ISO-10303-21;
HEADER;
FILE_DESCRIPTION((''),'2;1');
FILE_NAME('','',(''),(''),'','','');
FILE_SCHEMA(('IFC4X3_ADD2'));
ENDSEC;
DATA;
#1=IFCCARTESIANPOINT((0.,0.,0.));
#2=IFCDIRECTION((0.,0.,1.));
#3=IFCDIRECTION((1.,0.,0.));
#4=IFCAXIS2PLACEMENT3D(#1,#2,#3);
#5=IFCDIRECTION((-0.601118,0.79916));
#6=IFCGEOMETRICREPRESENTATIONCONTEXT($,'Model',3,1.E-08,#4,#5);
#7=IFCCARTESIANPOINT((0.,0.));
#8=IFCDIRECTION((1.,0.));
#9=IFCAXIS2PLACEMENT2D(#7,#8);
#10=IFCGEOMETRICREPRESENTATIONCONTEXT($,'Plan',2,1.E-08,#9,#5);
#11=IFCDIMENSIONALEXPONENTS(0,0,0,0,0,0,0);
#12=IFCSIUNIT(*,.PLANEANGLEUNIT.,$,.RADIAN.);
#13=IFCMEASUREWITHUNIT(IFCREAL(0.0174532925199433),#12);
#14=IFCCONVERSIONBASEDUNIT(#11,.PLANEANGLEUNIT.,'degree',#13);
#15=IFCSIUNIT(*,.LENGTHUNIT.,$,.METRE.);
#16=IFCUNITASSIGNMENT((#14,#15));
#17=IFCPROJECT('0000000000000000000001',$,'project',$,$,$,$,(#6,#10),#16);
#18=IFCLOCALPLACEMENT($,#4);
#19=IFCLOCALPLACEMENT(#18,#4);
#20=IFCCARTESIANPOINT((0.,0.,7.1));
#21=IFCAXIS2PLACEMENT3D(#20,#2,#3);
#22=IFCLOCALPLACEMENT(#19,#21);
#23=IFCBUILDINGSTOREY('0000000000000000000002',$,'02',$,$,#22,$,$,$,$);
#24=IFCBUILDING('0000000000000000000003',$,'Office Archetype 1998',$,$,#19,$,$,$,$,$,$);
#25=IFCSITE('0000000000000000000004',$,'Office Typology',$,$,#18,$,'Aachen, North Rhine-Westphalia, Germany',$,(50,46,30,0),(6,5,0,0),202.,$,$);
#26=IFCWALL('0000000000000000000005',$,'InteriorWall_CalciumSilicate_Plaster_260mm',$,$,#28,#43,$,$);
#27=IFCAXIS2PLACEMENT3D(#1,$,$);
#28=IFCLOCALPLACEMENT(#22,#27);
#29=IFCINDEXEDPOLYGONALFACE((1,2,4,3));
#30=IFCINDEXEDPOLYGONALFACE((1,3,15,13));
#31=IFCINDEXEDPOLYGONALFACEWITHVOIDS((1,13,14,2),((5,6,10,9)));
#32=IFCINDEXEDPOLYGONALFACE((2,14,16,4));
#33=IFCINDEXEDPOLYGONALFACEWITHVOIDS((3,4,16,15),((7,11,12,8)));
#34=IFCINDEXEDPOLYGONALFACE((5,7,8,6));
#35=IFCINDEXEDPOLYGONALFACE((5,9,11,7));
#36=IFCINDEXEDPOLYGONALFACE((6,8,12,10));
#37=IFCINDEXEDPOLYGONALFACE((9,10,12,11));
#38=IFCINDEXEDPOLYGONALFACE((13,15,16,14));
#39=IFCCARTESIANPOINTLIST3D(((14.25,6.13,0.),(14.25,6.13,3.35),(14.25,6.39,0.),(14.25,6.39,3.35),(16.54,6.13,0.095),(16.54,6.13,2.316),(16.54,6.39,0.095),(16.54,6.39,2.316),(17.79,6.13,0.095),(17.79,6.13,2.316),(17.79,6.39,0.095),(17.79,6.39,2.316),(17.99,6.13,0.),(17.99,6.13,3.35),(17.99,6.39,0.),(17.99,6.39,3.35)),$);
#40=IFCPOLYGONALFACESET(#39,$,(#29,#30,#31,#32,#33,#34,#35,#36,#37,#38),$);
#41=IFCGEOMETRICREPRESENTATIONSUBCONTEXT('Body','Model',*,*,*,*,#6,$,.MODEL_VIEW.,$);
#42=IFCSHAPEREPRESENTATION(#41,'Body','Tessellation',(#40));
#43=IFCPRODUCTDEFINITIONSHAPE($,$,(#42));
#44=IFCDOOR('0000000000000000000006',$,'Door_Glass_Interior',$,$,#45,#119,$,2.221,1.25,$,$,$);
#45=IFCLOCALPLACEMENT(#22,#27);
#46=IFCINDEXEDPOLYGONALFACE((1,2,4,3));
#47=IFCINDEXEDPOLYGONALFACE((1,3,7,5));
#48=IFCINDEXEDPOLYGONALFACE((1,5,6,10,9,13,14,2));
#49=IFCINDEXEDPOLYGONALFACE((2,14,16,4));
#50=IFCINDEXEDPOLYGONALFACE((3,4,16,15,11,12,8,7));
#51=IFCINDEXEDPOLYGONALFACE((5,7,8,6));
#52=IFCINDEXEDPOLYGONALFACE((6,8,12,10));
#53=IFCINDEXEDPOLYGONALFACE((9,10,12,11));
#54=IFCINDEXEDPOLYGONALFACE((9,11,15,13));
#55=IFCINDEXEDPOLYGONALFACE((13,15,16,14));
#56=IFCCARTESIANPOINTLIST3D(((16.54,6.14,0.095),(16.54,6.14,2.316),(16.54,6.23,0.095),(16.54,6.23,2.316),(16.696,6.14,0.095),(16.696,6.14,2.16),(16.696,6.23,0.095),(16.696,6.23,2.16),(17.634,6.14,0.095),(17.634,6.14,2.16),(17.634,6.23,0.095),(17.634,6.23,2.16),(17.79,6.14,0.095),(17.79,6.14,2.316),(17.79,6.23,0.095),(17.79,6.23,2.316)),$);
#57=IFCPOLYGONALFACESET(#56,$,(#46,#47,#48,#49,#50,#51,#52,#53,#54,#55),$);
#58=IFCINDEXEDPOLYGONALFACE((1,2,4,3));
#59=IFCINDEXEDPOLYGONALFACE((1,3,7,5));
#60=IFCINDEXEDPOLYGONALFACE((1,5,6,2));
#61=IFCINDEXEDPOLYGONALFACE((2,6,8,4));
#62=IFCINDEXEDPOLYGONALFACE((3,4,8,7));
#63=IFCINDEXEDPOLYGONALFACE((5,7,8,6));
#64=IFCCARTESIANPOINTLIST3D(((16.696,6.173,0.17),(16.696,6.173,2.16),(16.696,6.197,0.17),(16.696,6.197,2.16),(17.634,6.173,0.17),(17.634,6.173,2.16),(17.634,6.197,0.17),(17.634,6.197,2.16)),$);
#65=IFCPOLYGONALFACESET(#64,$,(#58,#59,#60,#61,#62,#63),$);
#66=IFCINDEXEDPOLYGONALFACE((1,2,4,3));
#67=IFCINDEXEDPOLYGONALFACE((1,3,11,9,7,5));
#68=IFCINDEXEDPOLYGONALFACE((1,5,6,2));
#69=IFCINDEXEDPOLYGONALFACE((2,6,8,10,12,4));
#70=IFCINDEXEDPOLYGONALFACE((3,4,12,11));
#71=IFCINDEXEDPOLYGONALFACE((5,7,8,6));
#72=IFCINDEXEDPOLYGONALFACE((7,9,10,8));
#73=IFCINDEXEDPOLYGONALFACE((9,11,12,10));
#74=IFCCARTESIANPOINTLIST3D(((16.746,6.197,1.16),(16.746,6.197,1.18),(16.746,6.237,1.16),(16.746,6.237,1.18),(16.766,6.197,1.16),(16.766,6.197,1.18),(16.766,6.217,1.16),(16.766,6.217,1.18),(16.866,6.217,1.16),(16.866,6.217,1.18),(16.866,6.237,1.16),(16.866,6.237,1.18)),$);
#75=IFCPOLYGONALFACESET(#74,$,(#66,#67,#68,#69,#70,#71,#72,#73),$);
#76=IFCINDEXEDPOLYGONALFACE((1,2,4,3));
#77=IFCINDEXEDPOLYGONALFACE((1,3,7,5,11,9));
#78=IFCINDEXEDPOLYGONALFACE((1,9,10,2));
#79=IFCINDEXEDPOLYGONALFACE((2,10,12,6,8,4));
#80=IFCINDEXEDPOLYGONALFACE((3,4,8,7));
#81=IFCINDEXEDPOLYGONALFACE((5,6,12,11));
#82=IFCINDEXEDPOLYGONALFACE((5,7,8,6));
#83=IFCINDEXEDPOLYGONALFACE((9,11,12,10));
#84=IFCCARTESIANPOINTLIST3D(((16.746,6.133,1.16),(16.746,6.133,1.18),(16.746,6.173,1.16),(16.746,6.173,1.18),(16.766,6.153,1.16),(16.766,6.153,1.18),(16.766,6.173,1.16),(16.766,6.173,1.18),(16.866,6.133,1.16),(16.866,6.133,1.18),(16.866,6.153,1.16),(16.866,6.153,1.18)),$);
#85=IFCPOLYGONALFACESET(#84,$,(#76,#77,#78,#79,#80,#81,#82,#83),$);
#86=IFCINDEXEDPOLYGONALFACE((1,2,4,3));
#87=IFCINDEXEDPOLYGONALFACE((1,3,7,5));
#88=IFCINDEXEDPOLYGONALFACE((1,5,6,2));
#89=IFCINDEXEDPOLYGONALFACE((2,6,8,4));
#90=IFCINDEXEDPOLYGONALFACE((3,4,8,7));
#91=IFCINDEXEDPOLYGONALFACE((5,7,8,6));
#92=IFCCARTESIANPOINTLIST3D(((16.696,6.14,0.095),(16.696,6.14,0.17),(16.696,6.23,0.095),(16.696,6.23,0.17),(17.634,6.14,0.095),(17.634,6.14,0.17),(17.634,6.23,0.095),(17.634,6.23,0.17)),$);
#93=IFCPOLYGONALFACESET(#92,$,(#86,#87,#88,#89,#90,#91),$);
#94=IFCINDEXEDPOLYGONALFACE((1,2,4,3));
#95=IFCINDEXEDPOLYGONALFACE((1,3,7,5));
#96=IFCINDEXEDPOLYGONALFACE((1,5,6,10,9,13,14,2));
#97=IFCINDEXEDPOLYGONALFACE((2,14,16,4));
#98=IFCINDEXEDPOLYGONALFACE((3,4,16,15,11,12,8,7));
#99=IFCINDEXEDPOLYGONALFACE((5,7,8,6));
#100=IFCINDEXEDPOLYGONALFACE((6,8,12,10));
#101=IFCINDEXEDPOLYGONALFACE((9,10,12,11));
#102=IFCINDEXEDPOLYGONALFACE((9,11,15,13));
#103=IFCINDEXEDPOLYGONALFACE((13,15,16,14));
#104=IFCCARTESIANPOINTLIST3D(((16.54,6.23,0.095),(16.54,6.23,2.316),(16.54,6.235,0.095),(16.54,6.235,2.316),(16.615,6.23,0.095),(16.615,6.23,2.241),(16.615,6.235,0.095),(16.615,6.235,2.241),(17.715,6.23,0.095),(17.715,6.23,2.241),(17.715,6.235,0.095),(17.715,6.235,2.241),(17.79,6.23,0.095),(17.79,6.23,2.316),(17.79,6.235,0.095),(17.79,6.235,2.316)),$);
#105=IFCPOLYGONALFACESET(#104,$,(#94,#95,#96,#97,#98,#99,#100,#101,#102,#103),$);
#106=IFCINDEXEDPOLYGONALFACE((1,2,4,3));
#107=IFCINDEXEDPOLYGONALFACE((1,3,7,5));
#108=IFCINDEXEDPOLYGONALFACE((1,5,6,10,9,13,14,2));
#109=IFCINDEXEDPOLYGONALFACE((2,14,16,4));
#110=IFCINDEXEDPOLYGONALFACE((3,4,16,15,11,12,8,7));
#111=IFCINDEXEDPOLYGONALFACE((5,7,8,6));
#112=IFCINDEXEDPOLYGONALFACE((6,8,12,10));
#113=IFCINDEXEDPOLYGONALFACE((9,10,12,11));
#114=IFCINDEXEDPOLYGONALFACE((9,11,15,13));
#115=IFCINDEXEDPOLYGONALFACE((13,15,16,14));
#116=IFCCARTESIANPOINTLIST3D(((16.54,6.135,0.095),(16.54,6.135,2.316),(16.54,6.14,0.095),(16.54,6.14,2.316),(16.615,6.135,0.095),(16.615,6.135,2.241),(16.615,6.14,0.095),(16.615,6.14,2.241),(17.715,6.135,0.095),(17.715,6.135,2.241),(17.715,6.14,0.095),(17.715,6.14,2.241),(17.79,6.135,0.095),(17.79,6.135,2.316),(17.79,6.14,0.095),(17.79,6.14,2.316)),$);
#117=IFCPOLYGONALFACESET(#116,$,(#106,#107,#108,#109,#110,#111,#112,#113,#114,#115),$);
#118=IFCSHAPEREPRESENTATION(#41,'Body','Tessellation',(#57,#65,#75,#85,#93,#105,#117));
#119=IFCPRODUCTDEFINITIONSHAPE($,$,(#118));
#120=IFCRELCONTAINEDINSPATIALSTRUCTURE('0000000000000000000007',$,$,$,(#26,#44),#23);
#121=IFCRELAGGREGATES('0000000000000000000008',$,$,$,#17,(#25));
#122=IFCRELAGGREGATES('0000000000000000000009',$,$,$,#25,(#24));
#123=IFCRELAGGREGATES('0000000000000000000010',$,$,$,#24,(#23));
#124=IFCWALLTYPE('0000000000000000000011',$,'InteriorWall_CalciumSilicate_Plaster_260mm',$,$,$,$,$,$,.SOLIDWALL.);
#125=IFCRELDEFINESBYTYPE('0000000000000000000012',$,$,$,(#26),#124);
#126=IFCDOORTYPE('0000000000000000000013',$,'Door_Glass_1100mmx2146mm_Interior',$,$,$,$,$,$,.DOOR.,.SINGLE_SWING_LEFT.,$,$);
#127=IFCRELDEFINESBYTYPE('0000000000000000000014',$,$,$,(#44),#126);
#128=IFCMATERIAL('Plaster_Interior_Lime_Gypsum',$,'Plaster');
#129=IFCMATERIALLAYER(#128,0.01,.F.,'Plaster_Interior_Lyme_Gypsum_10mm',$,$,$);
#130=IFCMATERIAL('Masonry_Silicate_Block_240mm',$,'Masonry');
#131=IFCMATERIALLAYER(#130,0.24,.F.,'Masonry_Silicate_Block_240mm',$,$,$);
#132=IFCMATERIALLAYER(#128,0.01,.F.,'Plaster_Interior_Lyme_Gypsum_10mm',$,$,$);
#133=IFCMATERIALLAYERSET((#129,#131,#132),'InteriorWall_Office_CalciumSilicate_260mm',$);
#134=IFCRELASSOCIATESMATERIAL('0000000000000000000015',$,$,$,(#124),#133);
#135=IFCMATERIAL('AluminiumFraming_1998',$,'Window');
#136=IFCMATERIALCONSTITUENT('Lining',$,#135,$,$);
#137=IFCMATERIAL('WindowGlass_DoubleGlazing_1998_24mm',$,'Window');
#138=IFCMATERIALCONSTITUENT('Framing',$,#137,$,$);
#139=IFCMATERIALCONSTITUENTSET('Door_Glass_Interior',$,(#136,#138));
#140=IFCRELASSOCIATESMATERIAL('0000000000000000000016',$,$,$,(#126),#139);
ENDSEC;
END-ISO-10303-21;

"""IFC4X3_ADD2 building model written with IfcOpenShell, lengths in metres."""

from ifc_helpers import new_model, entity, si_unit, converted_unit, direction, frame, origin_with_axes, origin_2d_with_axis, place, context, subcontext, project, spatial, line, indexed_curve, outline, extrude, source, transform, mapped, material, layer, layer_set, constituent, constituent_set, type_object, type_shapes, element, fill, save


model = new_model("IFC4X3_ADD2")

# Units and contexts
model_context = context("Model", 3, precision=1e-08, world=origin_with_axes(), true_north=direction((-0.601118, 0.79916)))
plan_context = context("Plan", 2, precision=1e-08, world=origin_2d_with_axis(), true_north=direction((-0.601118, 0.79916)))
body_context = subcontext(model_context, "Body", "Model", "MODEL_VIEW")
ifc_project = project(units=[converted_unit("PLANEANGLEUNIT", "degree", entity("IfcReal", 0.0174532925199433), si_unit("PLANEANGLEUNIT", "RADIAN"), dimensions=[0, 0, 0, 0, 0, 0, 0]), si_unit("LENGTHUNIT", "METRE")], contexts=[model_context, plan_context])

# Site, building, storey
site_placement = place(None, origin_with_axes())
site = spatial("IfcSite", under=ifc_project, at=site_placement, Name="Office Typology", LongName="Aachen, North Rhine-Westphalia, Germany", RefLatitude=(50, 46, 30, 0), RefLongitude=(6, 5, 0, 0), RefElevation=202.0)
building_placement = place(site_placement, origin_with_axes())
building = spatial("IfcBuilding", under=site, at=building_placement, Name="Office Archetype 1998")
storey_placement = place(building_placement, frame((0.0, 0.0, 7.1), z_axis=(0.0, 0.0, 1.0), x_axis=(1.0, 0.0, 0.0)))
storey = spatial("IfcBuildingStorey", under=building, at=storey_placement, Name="02")

# Shared definitions
ifc_material_1 = material(Name="Plaster_Interior_Lime_Gypsum", Category="Plaster")
ifc_layer_1 = layer(ifc_material_1, 0.01, ventilated=False, Name="Plaster_Interior_Lyme_Gypsum_10mm")
ifc_material_2 = material(Name="Masonry_Silicate_Block_240mm", Category="Masonry")
ifc_layer_2 = layer(ifc_material_2, 0.24, ventilated=False, Name="Masonry_Silicate_Block_240mm")
ifc_layer_3 = layer(ifc_material_1, 0.01, ventilated=False, Name="Plaster_Interior_Lyme_Gypsum_10mm")
ifc_layer_set_1 = layer_set([ifc_layer_1, ifc_layer_2, ifc_layer_3], Name="InteriorWall_Office_CalciumSilicate_260mm")
wall_type_1 = type_object("IfcWallType", Name="InteriorWall_CalciumSilicate_Plaster_260mm", PredefinedType="SOLIDWALL", material=ifc_layer_set_1)

# Wall, opening, door
wall_1_placement = place(storey_placement, frame((18.25, 6.39, 0.0), z_axis=(0.0, 0.0, 1.0), x_axis=(-1.0, 0.0, 0.0)))
wall_1 = element("IfcWall", 1, at=wall_1_placement, inside=storey, type_object=wall_type_1, Name="InteriorWall_CalciumSilicate_Plaster_260mm", context=body_context, shape_type="SweptSolid", body=[
    extrude(outline(indexed_curve([(0.26, 0.0), (0.26, 0.26), (4.0, 0.26), (4.0, 0.0)], segments=[line(1, 2, 3, 4, 1)])), origin_with_axes(), (0.0, 0.0, 1.0), 3.35),
])
shared_shape_1 = source(origin_with_axes(), body_context, "Body", "SweptSolid", [
    extrude(outline(indexed_curve([(0.0, 2.221), (1.25, 2.221), (1.25, 0.0), (0.0, 0.0), (0.0, 2.221)])), frame((0.0, -0.16, 0.0), z_axis=(0.0, -1.0, 0.0), x_axis=(1.0, 0.0, 0.0)), (0.0, 0.0, -1.0), 0.26),
])
opening_1_placement = place(wall_1_placement, frame((0.46, 0.16, 0.095), z_axis=(0.0, 0.0, 1.0), x_axis=(1.0, 0.0, 0.0)))
opening_1 = element("IfcOpeningElement", 2, at=opening_1_placement, cuts=wall_1, PredefinedType="OPENING", context=body_context, shape_type="MappedRepresentation", body=[
    mapped(shared_shape_1, transform((0.0, 0.0, 0.0), x_axis=(1.0, 0.0, 0.0), y_axis=(0.0, 1.0, 0.0), z_axis=(0.0, 0.0, 1.0), scale=1.0)),
])
ifc_material_3 = material(Name="AluminiumFraming_1998", Category="Window")
ifc_constituent_1 = constituent(ifc_material_3, Name="Lining")
ifc_material_4 = material(Name="WindowGlass_DoubleGlazing_1998_24mm", Category="Window")
ifc_constituent_2 = constituent(ifc_material_4, Name="Framing")
ifc_constituent_set_1 = constituent_set(constituents=[ifc_constituent_1, ifc_constituent_2], Name="Door_Glass_Interior")
door_type_1 = type_object("IfcDoorType", Name="Door_Glass_1100mmx2146mm_Interior", OperationType="SINGLE_SWING_LEFT", PredefinedType="DOOR", material=ifc_constituent_set_1)
shared_shape_2 = source(origin_with_axes(), body_context, "Body", "SweptSolid", [
    extrude(outline(indexed_curve([(0.0, 0.0), (0.0, 2.221), (1.25, 2.221), (1.25, 0.0), (1.094, 0.0), (1.094, 2.065), (0.156, 2.065), (0.156, 0.0)], segments=[line(1, 2, 3, 4, 5, 6, 7, 8, 1)])), frame((0.0, 0.0, 0.0), z_axis=(0.0, -1.0, 0.0), x_axis=(1.0, 0.0, 0.0)), (0.0, 0.0, -1.0), 0.09),
    extrude(outline(indexed_curve([(0.0, 0.0), (0.938, 0.0), (0.938, 0.024), (0.0, 0.024)], segments=[line(1, 2, 3, 4, 1)])), frame((0.156, 0.033, 0.075), z_axis=(0.0, 0.0, 1.0), x_axis=(1.0, 0.0, 0.0)), (0.0, 0.0, 1.0), 1.99),
    extrude(outline(indexed_curve([(0.0, 0.0), (0.0, -0.04), (-0.12, -0.04), (-0.12, -0.02), (-0.02, -0.02), (-0.02, 0.0)], segments=[line(1, 2, 3, 4, 5, 6, 1)])), frame((1.044, 0.033, 1.065), z_axis=(0.0, 0.0, 1.0), x_axis=(1.0, 0.0, 0.0)), (0.0, 0.0, 1.0), 0.02),
    extrude(outline(indexed_curve([(0.0, 0.0), (0.0, 0.04), (-0.12, 0.04), (-0.12, 0.02), (-0.02, 0.02), (-0.02, 0.0)], segments=[line(1, 2, 3, 4, 5, 6, 1)])), frame((1.044, 0.057, 1.065), z_axis=(0.0, 0.0, 1.0), x_axis=(1.0, 0.0, 0.0)), (0.0, 0.0, 1.0), 0.02),
    extrude(outline(indexed_curve([(0.0, 0.0), (0.938, 0.0), (0.938, 0.09), (0.0, 0.09)], segments=[line(1, 2, 3, 4, 1)])), frame((0.156, 0.0, 0.0), z_axis=(0.0, 0.0, 1.0), x_axis=(1.0, 0.0, 0.0)), (0.0, 0.0, 1.0), 0.075),
    extrude(outline(indexed_curve([(0.0, 0.0), (0.0, 2.221), (1.25, 2.221), (1.25, 0.0), (1.175, 0.0), (1.175, 2.146), (0.075, 2.146), (0.075, 0.0)], segments=[line(1, 2, 3, 4, 5, 6, 7, 8, 1)])), frame((0.0, -0.005, 0.0), z_axis=(0.0, -1.0, 0.0), x_axis=(1.0, 0.0, 0.0)), (0.0, 0.0, -1.0), 0.005),
    extrude(outline(indexed_curve([(0.0, 0.0), (0.0, 2.221), (1.25, 2.221), (1.25, 0.0), (1.175, 0.0), (1.175, 2.146), (0.075, 2.146), (0.075, 0.0)], segments=[line(1, 2, 3, 4, 5, 6, 7, 8, 1)])), frame((0.0, 0.09, 0.0), z_axis=(0.0, -1.0, 0.0), x_axis=(1.0, 0.0, 0.0)), (0.0, 0.0, -1.0), 0.005),
])
type_shapes(door_type_1, [shared_shape_2])
door_1_placement = place(opening_1_placement, origin_with_axes())
door_1 = element("IfcDoor", 3, at=door_1_placement, inside=storey, type_object=door_type_1, Name="Door_Glass_Interior", OverallHeight=2.221, OverallWidth=1.25, context=body_context, shape_type="MappedRepresentation", body=[
    mapped(shared_shape_2, transform((0.0, 0.0, 0.0), x_axis=(1.0, 0.0, 0.0), y_axis=(0.0, 1.0, 0.0), z_axis=(0.0, 0.0, 1.0), scale=1.0)),
])
fill(opening_1, door_1)

save(model, "model.ifc")
